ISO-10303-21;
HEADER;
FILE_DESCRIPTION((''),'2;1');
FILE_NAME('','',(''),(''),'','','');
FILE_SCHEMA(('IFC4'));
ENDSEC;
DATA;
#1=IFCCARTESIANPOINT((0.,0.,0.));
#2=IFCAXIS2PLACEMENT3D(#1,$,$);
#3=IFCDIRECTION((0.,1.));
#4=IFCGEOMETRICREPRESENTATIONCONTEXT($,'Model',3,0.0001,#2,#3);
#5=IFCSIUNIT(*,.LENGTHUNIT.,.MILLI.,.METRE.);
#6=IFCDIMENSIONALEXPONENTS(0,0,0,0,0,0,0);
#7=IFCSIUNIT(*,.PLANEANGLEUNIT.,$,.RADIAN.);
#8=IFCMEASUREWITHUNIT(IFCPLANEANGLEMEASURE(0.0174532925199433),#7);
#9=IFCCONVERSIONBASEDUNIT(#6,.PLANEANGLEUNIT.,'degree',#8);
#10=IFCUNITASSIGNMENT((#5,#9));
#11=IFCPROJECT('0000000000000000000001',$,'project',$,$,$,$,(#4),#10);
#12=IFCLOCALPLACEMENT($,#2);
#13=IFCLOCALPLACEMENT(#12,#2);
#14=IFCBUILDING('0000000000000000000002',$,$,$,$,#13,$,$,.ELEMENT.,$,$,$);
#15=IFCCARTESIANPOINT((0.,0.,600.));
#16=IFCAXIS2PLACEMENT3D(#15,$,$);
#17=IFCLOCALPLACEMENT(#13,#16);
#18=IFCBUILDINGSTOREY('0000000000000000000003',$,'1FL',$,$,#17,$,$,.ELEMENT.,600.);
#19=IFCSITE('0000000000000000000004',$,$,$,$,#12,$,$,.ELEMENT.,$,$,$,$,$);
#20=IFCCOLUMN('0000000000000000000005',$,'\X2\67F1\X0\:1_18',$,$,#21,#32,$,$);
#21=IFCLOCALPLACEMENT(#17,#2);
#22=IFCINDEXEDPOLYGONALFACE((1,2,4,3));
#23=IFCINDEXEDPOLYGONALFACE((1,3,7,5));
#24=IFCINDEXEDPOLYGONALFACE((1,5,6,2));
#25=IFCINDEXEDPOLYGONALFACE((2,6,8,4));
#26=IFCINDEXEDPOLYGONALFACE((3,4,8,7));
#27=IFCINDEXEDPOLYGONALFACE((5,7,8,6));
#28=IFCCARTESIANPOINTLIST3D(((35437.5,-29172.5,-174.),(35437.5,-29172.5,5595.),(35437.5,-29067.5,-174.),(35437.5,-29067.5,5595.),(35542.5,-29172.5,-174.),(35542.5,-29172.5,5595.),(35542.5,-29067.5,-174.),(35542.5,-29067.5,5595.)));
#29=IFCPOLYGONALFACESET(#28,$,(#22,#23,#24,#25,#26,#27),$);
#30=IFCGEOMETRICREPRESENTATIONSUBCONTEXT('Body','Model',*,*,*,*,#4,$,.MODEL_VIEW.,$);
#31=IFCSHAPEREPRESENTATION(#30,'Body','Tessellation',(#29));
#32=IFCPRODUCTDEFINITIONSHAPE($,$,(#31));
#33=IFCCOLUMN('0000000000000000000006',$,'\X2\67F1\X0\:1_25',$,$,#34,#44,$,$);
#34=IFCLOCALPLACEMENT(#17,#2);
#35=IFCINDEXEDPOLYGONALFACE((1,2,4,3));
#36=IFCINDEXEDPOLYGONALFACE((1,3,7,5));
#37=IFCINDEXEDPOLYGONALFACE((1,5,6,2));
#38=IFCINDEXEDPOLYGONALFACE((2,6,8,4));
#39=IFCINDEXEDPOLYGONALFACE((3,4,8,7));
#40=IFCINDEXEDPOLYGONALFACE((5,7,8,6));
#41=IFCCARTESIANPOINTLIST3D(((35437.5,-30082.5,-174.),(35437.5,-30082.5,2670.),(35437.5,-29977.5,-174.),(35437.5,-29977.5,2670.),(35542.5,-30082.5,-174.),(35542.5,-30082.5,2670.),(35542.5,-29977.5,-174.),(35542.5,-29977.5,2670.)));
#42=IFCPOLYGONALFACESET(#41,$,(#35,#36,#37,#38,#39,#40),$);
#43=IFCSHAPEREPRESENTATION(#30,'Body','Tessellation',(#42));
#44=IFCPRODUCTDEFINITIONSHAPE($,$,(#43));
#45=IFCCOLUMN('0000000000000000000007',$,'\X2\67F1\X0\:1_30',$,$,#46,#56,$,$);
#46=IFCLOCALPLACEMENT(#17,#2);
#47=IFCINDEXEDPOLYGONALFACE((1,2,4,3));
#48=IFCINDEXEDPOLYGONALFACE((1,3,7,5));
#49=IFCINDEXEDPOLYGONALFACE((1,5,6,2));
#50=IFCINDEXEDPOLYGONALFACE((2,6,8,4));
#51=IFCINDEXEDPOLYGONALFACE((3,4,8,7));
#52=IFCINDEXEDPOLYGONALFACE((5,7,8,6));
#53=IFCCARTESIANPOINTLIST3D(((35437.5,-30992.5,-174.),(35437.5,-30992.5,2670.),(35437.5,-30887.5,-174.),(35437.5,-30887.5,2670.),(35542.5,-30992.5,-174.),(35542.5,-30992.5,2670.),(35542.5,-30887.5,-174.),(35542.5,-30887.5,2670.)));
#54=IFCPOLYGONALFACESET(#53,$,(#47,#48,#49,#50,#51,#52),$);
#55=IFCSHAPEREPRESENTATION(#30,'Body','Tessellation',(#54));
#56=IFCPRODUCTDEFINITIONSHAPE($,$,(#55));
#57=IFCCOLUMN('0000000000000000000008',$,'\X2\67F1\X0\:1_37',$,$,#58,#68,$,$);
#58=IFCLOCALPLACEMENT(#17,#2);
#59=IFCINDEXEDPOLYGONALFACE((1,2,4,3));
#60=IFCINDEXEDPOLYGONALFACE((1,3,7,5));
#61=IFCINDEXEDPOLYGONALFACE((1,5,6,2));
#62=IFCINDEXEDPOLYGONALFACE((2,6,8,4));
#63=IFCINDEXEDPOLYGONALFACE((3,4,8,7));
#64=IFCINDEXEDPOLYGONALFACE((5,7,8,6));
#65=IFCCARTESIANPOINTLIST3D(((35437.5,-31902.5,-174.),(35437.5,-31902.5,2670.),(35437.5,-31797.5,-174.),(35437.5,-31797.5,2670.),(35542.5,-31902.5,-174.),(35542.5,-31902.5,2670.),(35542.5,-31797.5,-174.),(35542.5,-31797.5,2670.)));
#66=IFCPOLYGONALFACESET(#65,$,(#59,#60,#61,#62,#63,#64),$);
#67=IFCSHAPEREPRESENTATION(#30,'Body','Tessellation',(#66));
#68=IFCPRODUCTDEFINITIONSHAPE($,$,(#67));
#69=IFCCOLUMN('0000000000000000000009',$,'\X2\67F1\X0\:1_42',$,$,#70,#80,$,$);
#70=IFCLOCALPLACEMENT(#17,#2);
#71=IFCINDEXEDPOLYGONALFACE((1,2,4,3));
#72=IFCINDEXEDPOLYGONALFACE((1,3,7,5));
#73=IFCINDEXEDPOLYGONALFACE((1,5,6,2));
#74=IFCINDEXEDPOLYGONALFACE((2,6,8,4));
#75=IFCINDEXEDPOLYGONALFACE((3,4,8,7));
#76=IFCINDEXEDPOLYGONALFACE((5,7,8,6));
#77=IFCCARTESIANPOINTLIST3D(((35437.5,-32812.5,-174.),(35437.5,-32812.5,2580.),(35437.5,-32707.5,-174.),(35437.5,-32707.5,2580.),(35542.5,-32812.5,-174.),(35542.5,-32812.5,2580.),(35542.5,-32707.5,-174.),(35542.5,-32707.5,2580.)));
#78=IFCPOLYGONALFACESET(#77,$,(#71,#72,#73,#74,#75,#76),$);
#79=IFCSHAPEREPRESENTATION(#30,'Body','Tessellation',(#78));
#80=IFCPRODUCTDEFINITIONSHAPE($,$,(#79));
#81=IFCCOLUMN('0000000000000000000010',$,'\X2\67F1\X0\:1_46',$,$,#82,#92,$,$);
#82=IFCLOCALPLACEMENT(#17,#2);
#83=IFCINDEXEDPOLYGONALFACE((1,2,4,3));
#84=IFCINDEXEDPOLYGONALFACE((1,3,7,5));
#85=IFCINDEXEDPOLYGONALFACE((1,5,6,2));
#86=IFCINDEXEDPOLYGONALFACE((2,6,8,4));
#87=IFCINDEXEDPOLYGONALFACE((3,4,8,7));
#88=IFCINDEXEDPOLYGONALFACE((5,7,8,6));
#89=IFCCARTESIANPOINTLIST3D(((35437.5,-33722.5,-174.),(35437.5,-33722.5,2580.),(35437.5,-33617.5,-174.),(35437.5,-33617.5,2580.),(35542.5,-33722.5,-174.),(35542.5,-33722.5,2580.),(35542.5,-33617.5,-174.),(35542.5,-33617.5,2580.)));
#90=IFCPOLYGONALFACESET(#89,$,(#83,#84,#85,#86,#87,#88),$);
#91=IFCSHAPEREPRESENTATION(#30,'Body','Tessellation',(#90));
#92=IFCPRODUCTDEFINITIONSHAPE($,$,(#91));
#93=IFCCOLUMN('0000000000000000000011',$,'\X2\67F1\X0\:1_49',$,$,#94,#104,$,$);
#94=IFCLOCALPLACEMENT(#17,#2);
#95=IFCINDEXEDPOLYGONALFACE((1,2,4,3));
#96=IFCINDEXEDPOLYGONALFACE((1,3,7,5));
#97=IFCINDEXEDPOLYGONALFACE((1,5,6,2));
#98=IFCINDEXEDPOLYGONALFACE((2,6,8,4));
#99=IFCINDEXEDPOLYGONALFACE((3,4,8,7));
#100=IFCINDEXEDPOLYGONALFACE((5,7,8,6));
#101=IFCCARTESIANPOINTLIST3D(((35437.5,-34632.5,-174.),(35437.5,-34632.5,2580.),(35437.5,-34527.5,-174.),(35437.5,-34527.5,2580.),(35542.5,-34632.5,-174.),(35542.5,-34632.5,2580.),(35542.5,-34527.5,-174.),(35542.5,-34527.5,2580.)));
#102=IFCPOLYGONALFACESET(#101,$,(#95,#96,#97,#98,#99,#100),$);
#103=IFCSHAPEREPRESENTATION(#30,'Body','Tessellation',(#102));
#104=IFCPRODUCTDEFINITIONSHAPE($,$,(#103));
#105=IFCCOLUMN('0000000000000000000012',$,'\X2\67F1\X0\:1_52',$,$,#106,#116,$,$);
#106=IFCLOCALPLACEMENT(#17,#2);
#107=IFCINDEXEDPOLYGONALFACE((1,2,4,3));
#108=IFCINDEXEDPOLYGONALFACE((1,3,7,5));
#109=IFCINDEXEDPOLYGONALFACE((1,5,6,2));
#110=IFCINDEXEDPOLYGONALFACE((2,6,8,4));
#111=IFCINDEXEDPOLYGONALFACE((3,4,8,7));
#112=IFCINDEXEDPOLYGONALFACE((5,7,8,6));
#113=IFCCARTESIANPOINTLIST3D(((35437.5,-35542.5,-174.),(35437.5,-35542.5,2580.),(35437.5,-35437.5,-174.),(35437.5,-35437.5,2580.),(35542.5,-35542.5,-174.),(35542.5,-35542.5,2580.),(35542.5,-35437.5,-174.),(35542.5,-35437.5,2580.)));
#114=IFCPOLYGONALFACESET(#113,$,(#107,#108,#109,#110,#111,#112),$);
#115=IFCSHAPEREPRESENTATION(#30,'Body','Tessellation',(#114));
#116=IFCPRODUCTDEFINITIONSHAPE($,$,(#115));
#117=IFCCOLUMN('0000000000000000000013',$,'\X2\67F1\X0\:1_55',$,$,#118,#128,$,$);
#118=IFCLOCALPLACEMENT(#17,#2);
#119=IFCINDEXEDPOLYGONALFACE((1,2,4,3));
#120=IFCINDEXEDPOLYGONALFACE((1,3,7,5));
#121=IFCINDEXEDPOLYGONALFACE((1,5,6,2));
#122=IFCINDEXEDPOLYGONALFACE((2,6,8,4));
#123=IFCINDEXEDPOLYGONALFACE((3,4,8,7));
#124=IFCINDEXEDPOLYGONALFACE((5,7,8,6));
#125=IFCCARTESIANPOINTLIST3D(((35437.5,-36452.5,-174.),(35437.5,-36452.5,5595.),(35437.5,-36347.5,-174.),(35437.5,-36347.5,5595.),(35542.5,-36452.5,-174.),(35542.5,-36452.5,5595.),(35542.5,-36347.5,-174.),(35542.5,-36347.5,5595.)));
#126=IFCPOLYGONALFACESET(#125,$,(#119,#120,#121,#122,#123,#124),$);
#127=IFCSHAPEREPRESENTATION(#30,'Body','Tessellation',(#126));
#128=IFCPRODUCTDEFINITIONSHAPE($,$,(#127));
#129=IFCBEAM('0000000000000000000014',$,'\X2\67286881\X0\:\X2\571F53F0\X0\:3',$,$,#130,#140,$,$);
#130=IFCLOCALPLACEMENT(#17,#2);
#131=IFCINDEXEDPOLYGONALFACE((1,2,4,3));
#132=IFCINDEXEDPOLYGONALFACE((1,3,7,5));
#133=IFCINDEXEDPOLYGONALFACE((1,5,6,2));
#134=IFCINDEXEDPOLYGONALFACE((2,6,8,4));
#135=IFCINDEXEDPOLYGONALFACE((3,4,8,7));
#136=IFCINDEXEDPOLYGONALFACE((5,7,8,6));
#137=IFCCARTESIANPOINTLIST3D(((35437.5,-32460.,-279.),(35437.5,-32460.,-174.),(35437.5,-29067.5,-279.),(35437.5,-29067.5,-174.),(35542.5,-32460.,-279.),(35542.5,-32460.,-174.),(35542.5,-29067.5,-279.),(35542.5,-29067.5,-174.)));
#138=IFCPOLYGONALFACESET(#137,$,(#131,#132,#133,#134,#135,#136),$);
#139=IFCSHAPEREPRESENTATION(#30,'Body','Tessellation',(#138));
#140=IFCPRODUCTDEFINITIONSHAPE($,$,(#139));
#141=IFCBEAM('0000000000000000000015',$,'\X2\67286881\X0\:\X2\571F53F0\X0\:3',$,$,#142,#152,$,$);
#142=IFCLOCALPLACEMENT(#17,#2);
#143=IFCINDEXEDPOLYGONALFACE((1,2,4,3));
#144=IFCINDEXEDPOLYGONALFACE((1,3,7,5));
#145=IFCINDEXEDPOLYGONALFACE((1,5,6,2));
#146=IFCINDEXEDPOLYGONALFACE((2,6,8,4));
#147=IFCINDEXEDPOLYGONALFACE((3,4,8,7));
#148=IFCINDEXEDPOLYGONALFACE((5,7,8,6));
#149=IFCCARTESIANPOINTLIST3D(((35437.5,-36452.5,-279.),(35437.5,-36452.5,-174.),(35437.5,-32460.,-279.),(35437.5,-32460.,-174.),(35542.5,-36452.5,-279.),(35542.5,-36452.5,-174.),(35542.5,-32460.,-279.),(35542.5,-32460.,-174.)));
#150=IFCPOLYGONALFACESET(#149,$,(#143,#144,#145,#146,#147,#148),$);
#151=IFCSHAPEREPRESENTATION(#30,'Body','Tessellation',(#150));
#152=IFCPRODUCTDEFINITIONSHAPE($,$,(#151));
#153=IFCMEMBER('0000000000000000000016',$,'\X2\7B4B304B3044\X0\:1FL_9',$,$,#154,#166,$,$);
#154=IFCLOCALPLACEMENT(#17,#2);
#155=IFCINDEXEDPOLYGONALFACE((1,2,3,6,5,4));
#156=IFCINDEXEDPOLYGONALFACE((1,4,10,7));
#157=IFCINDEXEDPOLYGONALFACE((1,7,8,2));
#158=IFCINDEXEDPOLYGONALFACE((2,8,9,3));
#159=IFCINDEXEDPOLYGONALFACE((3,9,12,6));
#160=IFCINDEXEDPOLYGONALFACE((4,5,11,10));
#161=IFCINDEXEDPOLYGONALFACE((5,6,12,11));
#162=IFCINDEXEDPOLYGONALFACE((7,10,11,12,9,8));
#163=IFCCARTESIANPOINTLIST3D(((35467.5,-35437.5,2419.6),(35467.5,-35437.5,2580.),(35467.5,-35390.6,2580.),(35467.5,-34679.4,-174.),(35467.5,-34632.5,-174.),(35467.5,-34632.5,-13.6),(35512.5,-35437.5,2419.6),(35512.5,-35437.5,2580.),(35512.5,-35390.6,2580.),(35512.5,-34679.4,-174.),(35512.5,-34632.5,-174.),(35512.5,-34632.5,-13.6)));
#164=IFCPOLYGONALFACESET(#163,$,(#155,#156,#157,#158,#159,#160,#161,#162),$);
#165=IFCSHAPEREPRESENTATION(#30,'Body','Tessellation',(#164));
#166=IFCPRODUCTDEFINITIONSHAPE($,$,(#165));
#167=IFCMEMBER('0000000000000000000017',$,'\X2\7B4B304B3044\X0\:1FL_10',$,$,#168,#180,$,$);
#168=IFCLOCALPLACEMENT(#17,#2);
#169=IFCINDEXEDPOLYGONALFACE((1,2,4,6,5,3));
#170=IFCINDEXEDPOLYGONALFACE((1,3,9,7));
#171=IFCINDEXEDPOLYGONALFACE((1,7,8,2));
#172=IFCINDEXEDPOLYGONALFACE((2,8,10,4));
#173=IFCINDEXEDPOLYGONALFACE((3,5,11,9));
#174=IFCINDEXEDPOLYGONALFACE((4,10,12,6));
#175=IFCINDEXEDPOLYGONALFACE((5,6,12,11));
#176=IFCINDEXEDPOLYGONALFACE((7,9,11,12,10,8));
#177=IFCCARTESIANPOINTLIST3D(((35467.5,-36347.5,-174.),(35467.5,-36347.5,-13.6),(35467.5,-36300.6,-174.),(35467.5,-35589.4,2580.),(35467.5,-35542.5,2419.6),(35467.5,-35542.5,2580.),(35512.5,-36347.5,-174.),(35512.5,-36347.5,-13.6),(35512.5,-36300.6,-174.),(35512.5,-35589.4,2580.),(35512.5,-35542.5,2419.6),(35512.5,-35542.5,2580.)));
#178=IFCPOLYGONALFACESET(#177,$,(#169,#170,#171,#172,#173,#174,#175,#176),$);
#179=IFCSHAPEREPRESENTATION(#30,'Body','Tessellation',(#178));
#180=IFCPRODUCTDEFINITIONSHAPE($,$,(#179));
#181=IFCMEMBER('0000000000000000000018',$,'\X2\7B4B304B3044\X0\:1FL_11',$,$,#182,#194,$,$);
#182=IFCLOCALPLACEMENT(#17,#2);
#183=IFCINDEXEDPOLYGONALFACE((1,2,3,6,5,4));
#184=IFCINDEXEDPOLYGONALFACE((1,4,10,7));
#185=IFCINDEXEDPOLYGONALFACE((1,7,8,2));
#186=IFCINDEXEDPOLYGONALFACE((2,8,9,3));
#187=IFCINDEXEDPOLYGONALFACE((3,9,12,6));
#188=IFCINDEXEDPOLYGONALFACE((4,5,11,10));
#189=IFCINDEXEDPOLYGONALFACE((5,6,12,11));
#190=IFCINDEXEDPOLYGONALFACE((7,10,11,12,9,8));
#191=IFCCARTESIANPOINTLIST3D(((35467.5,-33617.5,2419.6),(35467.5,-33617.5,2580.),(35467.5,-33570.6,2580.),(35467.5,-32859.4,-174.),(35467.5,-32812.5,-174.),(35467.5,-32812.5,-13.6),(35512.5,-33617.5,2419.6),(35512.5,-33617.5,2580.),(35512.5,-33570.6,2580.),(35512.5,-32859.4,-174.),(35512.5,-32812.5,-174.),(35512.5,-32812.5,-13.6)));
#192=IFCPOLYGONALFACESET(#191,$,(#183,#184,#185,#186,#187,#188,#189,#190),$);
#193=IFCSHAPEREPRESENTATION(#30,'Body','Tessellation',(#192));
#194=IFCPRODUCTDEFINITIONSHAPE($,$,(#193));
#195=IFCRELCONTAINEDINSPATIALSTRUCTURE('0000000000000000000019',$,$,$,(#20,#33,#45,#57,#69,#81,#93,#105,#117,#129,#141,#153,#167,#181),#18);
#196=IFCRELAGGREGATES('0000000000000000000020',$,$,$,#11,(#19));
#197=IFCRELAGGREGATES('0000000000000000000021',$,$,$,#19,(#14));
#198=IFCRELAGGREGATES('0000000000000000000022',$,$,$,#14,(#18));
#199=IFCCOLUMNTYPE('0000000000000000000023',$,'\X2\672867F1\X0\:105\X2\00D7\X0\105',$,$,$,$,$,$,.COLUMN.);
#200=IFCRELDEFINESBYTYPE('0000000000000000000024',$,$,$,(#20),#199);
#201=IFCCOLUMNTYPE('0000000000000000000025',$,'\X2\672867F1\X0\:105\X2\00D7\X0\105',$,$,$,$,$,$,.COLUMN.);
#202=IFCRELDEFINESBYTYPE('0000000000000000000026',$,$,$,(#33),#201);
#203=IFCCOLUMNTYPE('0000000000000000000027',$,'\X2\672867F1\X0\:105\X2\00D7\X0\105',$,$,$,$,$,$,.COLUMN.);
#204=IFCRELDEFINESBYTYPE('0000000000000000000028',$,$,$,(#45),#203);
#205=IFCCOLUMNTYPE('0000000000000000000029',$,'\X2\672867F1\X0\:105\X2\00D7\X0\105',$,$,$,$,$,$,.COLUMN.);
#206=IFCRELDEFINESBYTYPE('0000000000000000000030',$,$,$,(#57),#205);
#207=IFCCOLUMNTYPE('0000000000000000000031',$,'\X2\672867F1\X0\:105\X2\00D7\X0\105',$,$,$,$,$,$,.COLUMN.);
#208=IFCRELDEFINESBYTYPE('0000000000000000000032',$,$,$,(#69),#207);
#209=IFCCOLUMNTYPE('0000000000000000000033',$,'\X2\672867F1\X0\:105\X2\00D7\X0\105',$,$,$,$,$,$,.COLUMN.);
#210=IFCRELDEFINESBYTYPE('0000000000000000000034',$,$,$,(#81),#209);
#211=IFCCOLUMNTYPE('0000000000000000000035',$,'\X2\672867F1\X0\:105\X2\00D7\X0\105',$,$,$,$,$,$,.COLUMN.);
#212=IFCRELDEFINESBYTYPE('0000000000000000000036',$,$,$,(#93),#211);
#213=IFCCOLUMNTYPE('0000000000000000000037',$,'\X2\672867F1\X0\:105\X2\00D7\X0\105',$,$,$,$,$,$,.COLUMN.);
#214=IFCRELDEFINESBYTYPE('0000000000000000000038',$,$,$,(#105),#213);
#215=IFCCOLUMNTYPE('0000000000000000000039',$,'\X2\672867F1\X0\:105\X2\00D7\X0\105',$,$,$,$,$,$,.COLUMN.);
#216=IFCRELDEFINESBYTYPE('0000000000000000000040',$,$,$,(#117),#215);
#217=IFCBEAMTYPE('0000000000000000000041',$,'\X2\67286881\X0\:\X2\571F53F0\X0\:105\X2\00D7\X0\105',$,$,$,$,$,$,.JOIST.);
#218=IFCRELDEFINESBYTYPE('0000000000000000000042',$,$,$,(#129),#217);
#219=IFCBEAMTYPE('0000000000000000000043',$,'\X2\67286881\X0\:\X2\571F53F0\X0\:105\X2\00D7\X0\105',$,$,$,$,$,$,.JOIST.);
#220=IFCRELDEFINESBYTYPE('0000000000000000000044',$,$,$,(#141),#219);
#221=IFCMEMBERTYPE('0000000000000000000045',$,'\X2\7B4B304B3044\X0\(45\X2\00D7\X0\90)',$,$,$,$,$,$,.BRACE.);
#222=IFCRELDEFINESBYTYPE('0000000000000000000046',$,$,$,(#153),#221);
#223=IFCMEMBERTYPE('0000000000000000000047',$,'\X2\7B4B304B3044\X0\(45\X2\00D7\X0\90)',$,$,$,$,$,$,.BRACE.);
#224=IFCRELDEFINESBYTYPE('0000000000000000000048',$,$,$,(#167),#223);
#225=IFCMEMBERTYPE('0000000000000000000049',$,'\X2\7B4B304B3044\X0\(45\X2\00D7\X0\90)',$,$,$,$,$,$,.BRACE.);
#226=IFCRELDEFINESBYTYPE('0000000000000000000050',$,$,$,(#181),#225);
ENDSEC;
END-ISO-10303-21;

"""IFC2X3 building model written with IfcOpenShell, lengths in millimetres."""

from ifc_helpers import new_model, entity, si_unit, converted_unit, direction, frame, origin, origin_with_axes, origin_2d, place, context, subcontext, project, spatial, polyline, rectangle, outline, extrude, type_object, element, save


model = new_model("IFC2X3")

# Units and contexts
model_context = context("Model", 3, precision=0.0001, world=origin(), true_north=direction((0.0, 1.0)))
body_context = subcontext(model_context, "Body", "Model", "MODEL_VIEW")
ifc_project = project(units=[si_unit("LENGTHUNIT", "METRE", prefix="MILLI"), converted_unit("PLANEANGLEUNIT", "degree", entity("IfcPlaneAngleMeasure", 0.0174532925199433), si_unit("PLANEANGLEUNIT", "RADIAN"), dimensions=[0, 0, 0, 0, 0, 0, 0])], contexts=[model_context])

# Site, building, storey
site_placement = place(None, origin())
site = spatial("IfcSite", under=ifc_project, at=site_placement, CompositionType="ELEMENT")
building_placement = place(site_placement, origin())
building = spatial("IfcBuilding", under=site, at=building_placement, CompositionType="ELEMENT")
storey_placement = place(building_placement, frame((0.0, 0.0, 600.0)))
storey = spatial("IfcBuildingStorey", under=building, at=storey_placement, Name="1FL", CompositionType="ELEMENT", Elevation=600.0)

# Columns
column_type_1 = type_object("IfcColumnType", Name="木柱:105×105", PredefinedType="COLUMN")
column_1_placement = place(storey_placement, frame((35490.0, -29120.0, -174.0)))
element("IfcColumn", 1, at=column_1_placement, inside=storey, type_object=column_type_1, Name="柱:1_18", context=body_context, shape_type="SweptSolid", body=[
    extrude(rectangle(XDim=105.0, YDim=105.0, at=origin_2d()), origin_with_axes(), (0.0, 0.0, 1.0), 5769.0),
])
column_type_2 = type_object("IfcColumnType", Name="木柱:105×105", PredefinedType="COLUMN")
column_2_placement = place(storey_placement, frame((35490.0, -30030.0, -174.0)))
element("IfcColumn", 2, at=column_2_placement, inside=storey, type_object=column_type_2, Name="柱:1_25", context=body_context, shape_type="SweptSolid", body=[
    extrude(rectangle(XDim=105.0, YDim=105.0, at=origin_2d()), origin_with_axes(), (0.0, 0.0, 1.0), 2844.0),
])
column_type_3 = type_object("IfcColumnType", Name="木柱:105×105", PredefinedType="COLUMN")
column_3_placement = place(storey_placement, frame((35490.0, -30940.0, -174.0)))
element("IfcColumn", 3, at=column_3_placement, inside=storey, type_object=column_type_3, Name="柱:1_30", context=body_context, shape_type="SweptSolid", body=[
    extrude(rectangle(XDim=105.0, YDim=105.0, at=origin_2d()), origin_with_axes(), (0.0, 0.0, 1.0), 2844.0),
])
column_type_4 = type_object("IfcColumnType", Name="木柱:105×105", PredefinedType="COLUMN")
column_4_placement = place(storey_placement, frame((35490.0, -31850.0, -174.0)))
element("IfcColumn", 4, at=column_4_placement, inside=storey, type_object=column_type_4, Name="柱:1_37", context=body_context, shape_type="SweptSolid", body=[
    extrude(rectangle(XDim=105.0, YDim=105.0, at=origin_2d()), origin_with_axes(), (0.0, 0.0, 1.0), 2844.0),
])
column_type_5 = type_object("IfcColumnType", Name="木柱:105×105", PredefinedType="COLUMN")
column_5_placement = place(storey_placement, frame((35490.0, -32760.0, -174.0)))
element("IfcColumn", 5, at=column_5_placement, inside=storey, type_object=column_type_5, Name="柱:1_42", context=body_context, shape_type="SweptSolid", body=[
    extrude(rectangle(XDim=105.0, YDim=105.0, at=origin_2d()), origin_with_axes(), (0.0, 0.0, 1.0), 2754.0),
])
column_type_6 = type_object("IfcColumnType", Name="木柱:105×105", PredefinedType="COLUMN")
column_6_placement = place(storey_placement, frame((35490.0, -33670.0, -174.0)))
element("IfcColumn", 6, at=column_6_placement, inside=storey, type_object=column_type_6, Name="柱:1_46", context=body_context, shape_type="SweptSolid", body=[
    extrude(rectangle(XDim=105.0, YDim=105.0, at=origin_2d()), origin_with_axes(), (0.0, 0.0, 1.0), 2754.0),
])
column_type_7 = type_object("IfcColumnType", Name="木柱:105×105", PredefinedType="COLUMN")
column_7_placement = place(storey_placement, frame((35490.0, -34580.0, -174.0)))
element("IfcColumn", 7, at=column_7_placement, inside=storey, type_object=column_type_7, Name="柱:1_49", context=body_context, shape_type="SweptSolid", body=[
    extrude(rectangle(XDim=105.0, YDim=105.0, at=origin_2d()), origin_with_axes(), (0.0, 0.0, 1.0), 2754.0),
])
column_type_8 = type_object("IfcColumnType", Name="木柱:105×105", PredefinedType="COLUMN")
column_8_placement = place(storey_placement, frame((35490.0, -35490.0, -174.0)))
element("IfcColumn", 8, at=column_8_placement, inside=storey, type_object=column_type_8, Name="柱:1_52", context=body_context, shape_type="SweptSolid", body=[
    extrude(rectangle(XDim=105.0, YDim=105.0, at=origin_2d()), origin_with_axes(), (0.0, 0.0, 1.0), 2754.0),
])
column_type_9 = type_object("IfcColumnType", Name="木柱:105×105", PredefinedType="COLUMN")
column_9_placement = place(storey_placement, frame((35490.0, -36400.0, -174.0)))
element("IfcColumn", 9, at=column_9_placement, inside=storey, type_object=column_type_9, Name="柱:1_55", context=body_context, shape_type="SweptSolid", body=[
    extrude(rectangle(XDim=105.0, YDim=105.0, at=origin_2d()), origin_with_axes(), (0.0, 0.0, 1.0), 5769.0),
])

# Beams
beam_type_1 = type_object("IfcBeamType", Name="木梁:土台:105×105", PredefinedType="JOIST")
beam_1_placement = place(storey_placement, frame((35490.0, -29067.5, -226.5), z_axis=(0.0, -1.0, 0.0), x_axis=(1.0, 0.0, 0.0)))
element("IfcBeam", 10, at=beam_1_placement, inside=storey, type_object=beam_type_1, Name="木梁:土台:3", context=body_context, shape_type="SweptSolid", body=[
    extrude(rectangle(XDim=105.0, YDim=105.0, at=origin_2d()), origin_with_axes(), (0.0, 0.0, 1.0), 3392.5),
])
beam_type_2 = type_object("IfcBeamType", Name="木梁:土台:105×105", PredefinedType="JOIST")
beam_2_placement = place(storey_placement, frame((35490.0, -32460.0, -226.5), z_axis=(0.0, -1.0, 0.0), x_axis=(1.0, 0.0, 0.0)))
element("IfcBeam", 11, at=beam_2_placement, inside=storey, type_object=beam_type_2, Name="木梁:土台:3", context=body_context, shape_type="SweptSolid", body=[
    extrude(rectangle(XDim=105.0, YDim=105.0, at=origin_2d()), origin_with_axes(), (0.0, 0.0, 1.0), 3992.5),
])

# Members
member_type_1 = type_object("IfcMemberType", Name="筋かい(45×90)", PredefinedType="BRACE")
member_1_placement = place(storey_placement, frame((35490.0, -34632.5, -174.0), z_axis=(0.0, -0.280562, 0.959836), x_axis=(0.0, 0.959836, 0.280562)))
element("IfcMember", 12, at=member_1_placement, inside=storey, type_object=member_type_1, Name="筋かい:1FL_9", context=body_context, shape_type="SweptSolid", body=[
    extrude(outline(polyline([(0.0, 0.0), (13.2, -45.0), (2715.3, -45.0), (2869.2, 0.0), (2856.1, 45.0), (154.0, 45.0), (0.0, 0.0)])), frame((0.0, -22.5, 0.0), z_axis=(0.0, 1.0, 0.0), x_axis=(0.0, 0.0, 1.0)), (0.0, 0.0, 1.0), 45.0),
])
member_type_2 = type_object("IfcMemberType", Name="筋かい(45×90)", PredefinedType="BRACE")
member_2_placement = place(storey_placement, frame((35490.0, -36347.5, -174.0), z_axis=(0.0, 0.280562, 0.959836), x_axis=(0.0, -0.959836, 0.280562)))
element("IfcMember", 13, at=member_2_placement, inside=storey, type_object=member_type_2, Name="筋かい:1FL_10", context=body_context, shape_type="SweptSolid", body=[
    extrude(outline(polyline([(0.0, 0.0), (13.2, -45.0), (2715.3, -45.0), (2869.2, 0.0), (2856.1, 45.0), (154.0, 45.0), (0.0, 0.0)])), frame((0.0, -22.5, 0.0), z_axis=(0.0, 1.0, 0.0), x_axis=(0.0, 0.0, 1.0)), (0.0, 0.0, 1.0), 45.0),
])
member_type_3 = type_object("IfcMemberType", Name="筋かい(45×90)", PredefinedType="BRACE")
member_3_placement = place(storey_placement, frame((35490.0, -32812.5, -174.0), z_axis=(0.0, -0.280562, 0.959836), x_axis=(0.0, 0.959836, 0.280562)))
element("IfcMember", 14, at=member_3_placement, inside=storey, type_object=member_type_3, Name="筋かい:1FL_11", context=body_context, shape_type="SweptSolid", body=[
    extrude(outline(polyline([(0.0, 0.0), (13.2, -45.0), (2715.3, -45.0), (2869.2, 0.0), (2856.1, 45.0), (154.0, 45.0), (0.0, 0.0)])), frame((0.0, -22.5, 0.0), z_axis=(0.0, 1.0, 0.0), x_axis=(0.0, 0.0, 1.0)), (0.0, 0.0, 1.0), 45.0),
])

save(model, "model.ifc")
